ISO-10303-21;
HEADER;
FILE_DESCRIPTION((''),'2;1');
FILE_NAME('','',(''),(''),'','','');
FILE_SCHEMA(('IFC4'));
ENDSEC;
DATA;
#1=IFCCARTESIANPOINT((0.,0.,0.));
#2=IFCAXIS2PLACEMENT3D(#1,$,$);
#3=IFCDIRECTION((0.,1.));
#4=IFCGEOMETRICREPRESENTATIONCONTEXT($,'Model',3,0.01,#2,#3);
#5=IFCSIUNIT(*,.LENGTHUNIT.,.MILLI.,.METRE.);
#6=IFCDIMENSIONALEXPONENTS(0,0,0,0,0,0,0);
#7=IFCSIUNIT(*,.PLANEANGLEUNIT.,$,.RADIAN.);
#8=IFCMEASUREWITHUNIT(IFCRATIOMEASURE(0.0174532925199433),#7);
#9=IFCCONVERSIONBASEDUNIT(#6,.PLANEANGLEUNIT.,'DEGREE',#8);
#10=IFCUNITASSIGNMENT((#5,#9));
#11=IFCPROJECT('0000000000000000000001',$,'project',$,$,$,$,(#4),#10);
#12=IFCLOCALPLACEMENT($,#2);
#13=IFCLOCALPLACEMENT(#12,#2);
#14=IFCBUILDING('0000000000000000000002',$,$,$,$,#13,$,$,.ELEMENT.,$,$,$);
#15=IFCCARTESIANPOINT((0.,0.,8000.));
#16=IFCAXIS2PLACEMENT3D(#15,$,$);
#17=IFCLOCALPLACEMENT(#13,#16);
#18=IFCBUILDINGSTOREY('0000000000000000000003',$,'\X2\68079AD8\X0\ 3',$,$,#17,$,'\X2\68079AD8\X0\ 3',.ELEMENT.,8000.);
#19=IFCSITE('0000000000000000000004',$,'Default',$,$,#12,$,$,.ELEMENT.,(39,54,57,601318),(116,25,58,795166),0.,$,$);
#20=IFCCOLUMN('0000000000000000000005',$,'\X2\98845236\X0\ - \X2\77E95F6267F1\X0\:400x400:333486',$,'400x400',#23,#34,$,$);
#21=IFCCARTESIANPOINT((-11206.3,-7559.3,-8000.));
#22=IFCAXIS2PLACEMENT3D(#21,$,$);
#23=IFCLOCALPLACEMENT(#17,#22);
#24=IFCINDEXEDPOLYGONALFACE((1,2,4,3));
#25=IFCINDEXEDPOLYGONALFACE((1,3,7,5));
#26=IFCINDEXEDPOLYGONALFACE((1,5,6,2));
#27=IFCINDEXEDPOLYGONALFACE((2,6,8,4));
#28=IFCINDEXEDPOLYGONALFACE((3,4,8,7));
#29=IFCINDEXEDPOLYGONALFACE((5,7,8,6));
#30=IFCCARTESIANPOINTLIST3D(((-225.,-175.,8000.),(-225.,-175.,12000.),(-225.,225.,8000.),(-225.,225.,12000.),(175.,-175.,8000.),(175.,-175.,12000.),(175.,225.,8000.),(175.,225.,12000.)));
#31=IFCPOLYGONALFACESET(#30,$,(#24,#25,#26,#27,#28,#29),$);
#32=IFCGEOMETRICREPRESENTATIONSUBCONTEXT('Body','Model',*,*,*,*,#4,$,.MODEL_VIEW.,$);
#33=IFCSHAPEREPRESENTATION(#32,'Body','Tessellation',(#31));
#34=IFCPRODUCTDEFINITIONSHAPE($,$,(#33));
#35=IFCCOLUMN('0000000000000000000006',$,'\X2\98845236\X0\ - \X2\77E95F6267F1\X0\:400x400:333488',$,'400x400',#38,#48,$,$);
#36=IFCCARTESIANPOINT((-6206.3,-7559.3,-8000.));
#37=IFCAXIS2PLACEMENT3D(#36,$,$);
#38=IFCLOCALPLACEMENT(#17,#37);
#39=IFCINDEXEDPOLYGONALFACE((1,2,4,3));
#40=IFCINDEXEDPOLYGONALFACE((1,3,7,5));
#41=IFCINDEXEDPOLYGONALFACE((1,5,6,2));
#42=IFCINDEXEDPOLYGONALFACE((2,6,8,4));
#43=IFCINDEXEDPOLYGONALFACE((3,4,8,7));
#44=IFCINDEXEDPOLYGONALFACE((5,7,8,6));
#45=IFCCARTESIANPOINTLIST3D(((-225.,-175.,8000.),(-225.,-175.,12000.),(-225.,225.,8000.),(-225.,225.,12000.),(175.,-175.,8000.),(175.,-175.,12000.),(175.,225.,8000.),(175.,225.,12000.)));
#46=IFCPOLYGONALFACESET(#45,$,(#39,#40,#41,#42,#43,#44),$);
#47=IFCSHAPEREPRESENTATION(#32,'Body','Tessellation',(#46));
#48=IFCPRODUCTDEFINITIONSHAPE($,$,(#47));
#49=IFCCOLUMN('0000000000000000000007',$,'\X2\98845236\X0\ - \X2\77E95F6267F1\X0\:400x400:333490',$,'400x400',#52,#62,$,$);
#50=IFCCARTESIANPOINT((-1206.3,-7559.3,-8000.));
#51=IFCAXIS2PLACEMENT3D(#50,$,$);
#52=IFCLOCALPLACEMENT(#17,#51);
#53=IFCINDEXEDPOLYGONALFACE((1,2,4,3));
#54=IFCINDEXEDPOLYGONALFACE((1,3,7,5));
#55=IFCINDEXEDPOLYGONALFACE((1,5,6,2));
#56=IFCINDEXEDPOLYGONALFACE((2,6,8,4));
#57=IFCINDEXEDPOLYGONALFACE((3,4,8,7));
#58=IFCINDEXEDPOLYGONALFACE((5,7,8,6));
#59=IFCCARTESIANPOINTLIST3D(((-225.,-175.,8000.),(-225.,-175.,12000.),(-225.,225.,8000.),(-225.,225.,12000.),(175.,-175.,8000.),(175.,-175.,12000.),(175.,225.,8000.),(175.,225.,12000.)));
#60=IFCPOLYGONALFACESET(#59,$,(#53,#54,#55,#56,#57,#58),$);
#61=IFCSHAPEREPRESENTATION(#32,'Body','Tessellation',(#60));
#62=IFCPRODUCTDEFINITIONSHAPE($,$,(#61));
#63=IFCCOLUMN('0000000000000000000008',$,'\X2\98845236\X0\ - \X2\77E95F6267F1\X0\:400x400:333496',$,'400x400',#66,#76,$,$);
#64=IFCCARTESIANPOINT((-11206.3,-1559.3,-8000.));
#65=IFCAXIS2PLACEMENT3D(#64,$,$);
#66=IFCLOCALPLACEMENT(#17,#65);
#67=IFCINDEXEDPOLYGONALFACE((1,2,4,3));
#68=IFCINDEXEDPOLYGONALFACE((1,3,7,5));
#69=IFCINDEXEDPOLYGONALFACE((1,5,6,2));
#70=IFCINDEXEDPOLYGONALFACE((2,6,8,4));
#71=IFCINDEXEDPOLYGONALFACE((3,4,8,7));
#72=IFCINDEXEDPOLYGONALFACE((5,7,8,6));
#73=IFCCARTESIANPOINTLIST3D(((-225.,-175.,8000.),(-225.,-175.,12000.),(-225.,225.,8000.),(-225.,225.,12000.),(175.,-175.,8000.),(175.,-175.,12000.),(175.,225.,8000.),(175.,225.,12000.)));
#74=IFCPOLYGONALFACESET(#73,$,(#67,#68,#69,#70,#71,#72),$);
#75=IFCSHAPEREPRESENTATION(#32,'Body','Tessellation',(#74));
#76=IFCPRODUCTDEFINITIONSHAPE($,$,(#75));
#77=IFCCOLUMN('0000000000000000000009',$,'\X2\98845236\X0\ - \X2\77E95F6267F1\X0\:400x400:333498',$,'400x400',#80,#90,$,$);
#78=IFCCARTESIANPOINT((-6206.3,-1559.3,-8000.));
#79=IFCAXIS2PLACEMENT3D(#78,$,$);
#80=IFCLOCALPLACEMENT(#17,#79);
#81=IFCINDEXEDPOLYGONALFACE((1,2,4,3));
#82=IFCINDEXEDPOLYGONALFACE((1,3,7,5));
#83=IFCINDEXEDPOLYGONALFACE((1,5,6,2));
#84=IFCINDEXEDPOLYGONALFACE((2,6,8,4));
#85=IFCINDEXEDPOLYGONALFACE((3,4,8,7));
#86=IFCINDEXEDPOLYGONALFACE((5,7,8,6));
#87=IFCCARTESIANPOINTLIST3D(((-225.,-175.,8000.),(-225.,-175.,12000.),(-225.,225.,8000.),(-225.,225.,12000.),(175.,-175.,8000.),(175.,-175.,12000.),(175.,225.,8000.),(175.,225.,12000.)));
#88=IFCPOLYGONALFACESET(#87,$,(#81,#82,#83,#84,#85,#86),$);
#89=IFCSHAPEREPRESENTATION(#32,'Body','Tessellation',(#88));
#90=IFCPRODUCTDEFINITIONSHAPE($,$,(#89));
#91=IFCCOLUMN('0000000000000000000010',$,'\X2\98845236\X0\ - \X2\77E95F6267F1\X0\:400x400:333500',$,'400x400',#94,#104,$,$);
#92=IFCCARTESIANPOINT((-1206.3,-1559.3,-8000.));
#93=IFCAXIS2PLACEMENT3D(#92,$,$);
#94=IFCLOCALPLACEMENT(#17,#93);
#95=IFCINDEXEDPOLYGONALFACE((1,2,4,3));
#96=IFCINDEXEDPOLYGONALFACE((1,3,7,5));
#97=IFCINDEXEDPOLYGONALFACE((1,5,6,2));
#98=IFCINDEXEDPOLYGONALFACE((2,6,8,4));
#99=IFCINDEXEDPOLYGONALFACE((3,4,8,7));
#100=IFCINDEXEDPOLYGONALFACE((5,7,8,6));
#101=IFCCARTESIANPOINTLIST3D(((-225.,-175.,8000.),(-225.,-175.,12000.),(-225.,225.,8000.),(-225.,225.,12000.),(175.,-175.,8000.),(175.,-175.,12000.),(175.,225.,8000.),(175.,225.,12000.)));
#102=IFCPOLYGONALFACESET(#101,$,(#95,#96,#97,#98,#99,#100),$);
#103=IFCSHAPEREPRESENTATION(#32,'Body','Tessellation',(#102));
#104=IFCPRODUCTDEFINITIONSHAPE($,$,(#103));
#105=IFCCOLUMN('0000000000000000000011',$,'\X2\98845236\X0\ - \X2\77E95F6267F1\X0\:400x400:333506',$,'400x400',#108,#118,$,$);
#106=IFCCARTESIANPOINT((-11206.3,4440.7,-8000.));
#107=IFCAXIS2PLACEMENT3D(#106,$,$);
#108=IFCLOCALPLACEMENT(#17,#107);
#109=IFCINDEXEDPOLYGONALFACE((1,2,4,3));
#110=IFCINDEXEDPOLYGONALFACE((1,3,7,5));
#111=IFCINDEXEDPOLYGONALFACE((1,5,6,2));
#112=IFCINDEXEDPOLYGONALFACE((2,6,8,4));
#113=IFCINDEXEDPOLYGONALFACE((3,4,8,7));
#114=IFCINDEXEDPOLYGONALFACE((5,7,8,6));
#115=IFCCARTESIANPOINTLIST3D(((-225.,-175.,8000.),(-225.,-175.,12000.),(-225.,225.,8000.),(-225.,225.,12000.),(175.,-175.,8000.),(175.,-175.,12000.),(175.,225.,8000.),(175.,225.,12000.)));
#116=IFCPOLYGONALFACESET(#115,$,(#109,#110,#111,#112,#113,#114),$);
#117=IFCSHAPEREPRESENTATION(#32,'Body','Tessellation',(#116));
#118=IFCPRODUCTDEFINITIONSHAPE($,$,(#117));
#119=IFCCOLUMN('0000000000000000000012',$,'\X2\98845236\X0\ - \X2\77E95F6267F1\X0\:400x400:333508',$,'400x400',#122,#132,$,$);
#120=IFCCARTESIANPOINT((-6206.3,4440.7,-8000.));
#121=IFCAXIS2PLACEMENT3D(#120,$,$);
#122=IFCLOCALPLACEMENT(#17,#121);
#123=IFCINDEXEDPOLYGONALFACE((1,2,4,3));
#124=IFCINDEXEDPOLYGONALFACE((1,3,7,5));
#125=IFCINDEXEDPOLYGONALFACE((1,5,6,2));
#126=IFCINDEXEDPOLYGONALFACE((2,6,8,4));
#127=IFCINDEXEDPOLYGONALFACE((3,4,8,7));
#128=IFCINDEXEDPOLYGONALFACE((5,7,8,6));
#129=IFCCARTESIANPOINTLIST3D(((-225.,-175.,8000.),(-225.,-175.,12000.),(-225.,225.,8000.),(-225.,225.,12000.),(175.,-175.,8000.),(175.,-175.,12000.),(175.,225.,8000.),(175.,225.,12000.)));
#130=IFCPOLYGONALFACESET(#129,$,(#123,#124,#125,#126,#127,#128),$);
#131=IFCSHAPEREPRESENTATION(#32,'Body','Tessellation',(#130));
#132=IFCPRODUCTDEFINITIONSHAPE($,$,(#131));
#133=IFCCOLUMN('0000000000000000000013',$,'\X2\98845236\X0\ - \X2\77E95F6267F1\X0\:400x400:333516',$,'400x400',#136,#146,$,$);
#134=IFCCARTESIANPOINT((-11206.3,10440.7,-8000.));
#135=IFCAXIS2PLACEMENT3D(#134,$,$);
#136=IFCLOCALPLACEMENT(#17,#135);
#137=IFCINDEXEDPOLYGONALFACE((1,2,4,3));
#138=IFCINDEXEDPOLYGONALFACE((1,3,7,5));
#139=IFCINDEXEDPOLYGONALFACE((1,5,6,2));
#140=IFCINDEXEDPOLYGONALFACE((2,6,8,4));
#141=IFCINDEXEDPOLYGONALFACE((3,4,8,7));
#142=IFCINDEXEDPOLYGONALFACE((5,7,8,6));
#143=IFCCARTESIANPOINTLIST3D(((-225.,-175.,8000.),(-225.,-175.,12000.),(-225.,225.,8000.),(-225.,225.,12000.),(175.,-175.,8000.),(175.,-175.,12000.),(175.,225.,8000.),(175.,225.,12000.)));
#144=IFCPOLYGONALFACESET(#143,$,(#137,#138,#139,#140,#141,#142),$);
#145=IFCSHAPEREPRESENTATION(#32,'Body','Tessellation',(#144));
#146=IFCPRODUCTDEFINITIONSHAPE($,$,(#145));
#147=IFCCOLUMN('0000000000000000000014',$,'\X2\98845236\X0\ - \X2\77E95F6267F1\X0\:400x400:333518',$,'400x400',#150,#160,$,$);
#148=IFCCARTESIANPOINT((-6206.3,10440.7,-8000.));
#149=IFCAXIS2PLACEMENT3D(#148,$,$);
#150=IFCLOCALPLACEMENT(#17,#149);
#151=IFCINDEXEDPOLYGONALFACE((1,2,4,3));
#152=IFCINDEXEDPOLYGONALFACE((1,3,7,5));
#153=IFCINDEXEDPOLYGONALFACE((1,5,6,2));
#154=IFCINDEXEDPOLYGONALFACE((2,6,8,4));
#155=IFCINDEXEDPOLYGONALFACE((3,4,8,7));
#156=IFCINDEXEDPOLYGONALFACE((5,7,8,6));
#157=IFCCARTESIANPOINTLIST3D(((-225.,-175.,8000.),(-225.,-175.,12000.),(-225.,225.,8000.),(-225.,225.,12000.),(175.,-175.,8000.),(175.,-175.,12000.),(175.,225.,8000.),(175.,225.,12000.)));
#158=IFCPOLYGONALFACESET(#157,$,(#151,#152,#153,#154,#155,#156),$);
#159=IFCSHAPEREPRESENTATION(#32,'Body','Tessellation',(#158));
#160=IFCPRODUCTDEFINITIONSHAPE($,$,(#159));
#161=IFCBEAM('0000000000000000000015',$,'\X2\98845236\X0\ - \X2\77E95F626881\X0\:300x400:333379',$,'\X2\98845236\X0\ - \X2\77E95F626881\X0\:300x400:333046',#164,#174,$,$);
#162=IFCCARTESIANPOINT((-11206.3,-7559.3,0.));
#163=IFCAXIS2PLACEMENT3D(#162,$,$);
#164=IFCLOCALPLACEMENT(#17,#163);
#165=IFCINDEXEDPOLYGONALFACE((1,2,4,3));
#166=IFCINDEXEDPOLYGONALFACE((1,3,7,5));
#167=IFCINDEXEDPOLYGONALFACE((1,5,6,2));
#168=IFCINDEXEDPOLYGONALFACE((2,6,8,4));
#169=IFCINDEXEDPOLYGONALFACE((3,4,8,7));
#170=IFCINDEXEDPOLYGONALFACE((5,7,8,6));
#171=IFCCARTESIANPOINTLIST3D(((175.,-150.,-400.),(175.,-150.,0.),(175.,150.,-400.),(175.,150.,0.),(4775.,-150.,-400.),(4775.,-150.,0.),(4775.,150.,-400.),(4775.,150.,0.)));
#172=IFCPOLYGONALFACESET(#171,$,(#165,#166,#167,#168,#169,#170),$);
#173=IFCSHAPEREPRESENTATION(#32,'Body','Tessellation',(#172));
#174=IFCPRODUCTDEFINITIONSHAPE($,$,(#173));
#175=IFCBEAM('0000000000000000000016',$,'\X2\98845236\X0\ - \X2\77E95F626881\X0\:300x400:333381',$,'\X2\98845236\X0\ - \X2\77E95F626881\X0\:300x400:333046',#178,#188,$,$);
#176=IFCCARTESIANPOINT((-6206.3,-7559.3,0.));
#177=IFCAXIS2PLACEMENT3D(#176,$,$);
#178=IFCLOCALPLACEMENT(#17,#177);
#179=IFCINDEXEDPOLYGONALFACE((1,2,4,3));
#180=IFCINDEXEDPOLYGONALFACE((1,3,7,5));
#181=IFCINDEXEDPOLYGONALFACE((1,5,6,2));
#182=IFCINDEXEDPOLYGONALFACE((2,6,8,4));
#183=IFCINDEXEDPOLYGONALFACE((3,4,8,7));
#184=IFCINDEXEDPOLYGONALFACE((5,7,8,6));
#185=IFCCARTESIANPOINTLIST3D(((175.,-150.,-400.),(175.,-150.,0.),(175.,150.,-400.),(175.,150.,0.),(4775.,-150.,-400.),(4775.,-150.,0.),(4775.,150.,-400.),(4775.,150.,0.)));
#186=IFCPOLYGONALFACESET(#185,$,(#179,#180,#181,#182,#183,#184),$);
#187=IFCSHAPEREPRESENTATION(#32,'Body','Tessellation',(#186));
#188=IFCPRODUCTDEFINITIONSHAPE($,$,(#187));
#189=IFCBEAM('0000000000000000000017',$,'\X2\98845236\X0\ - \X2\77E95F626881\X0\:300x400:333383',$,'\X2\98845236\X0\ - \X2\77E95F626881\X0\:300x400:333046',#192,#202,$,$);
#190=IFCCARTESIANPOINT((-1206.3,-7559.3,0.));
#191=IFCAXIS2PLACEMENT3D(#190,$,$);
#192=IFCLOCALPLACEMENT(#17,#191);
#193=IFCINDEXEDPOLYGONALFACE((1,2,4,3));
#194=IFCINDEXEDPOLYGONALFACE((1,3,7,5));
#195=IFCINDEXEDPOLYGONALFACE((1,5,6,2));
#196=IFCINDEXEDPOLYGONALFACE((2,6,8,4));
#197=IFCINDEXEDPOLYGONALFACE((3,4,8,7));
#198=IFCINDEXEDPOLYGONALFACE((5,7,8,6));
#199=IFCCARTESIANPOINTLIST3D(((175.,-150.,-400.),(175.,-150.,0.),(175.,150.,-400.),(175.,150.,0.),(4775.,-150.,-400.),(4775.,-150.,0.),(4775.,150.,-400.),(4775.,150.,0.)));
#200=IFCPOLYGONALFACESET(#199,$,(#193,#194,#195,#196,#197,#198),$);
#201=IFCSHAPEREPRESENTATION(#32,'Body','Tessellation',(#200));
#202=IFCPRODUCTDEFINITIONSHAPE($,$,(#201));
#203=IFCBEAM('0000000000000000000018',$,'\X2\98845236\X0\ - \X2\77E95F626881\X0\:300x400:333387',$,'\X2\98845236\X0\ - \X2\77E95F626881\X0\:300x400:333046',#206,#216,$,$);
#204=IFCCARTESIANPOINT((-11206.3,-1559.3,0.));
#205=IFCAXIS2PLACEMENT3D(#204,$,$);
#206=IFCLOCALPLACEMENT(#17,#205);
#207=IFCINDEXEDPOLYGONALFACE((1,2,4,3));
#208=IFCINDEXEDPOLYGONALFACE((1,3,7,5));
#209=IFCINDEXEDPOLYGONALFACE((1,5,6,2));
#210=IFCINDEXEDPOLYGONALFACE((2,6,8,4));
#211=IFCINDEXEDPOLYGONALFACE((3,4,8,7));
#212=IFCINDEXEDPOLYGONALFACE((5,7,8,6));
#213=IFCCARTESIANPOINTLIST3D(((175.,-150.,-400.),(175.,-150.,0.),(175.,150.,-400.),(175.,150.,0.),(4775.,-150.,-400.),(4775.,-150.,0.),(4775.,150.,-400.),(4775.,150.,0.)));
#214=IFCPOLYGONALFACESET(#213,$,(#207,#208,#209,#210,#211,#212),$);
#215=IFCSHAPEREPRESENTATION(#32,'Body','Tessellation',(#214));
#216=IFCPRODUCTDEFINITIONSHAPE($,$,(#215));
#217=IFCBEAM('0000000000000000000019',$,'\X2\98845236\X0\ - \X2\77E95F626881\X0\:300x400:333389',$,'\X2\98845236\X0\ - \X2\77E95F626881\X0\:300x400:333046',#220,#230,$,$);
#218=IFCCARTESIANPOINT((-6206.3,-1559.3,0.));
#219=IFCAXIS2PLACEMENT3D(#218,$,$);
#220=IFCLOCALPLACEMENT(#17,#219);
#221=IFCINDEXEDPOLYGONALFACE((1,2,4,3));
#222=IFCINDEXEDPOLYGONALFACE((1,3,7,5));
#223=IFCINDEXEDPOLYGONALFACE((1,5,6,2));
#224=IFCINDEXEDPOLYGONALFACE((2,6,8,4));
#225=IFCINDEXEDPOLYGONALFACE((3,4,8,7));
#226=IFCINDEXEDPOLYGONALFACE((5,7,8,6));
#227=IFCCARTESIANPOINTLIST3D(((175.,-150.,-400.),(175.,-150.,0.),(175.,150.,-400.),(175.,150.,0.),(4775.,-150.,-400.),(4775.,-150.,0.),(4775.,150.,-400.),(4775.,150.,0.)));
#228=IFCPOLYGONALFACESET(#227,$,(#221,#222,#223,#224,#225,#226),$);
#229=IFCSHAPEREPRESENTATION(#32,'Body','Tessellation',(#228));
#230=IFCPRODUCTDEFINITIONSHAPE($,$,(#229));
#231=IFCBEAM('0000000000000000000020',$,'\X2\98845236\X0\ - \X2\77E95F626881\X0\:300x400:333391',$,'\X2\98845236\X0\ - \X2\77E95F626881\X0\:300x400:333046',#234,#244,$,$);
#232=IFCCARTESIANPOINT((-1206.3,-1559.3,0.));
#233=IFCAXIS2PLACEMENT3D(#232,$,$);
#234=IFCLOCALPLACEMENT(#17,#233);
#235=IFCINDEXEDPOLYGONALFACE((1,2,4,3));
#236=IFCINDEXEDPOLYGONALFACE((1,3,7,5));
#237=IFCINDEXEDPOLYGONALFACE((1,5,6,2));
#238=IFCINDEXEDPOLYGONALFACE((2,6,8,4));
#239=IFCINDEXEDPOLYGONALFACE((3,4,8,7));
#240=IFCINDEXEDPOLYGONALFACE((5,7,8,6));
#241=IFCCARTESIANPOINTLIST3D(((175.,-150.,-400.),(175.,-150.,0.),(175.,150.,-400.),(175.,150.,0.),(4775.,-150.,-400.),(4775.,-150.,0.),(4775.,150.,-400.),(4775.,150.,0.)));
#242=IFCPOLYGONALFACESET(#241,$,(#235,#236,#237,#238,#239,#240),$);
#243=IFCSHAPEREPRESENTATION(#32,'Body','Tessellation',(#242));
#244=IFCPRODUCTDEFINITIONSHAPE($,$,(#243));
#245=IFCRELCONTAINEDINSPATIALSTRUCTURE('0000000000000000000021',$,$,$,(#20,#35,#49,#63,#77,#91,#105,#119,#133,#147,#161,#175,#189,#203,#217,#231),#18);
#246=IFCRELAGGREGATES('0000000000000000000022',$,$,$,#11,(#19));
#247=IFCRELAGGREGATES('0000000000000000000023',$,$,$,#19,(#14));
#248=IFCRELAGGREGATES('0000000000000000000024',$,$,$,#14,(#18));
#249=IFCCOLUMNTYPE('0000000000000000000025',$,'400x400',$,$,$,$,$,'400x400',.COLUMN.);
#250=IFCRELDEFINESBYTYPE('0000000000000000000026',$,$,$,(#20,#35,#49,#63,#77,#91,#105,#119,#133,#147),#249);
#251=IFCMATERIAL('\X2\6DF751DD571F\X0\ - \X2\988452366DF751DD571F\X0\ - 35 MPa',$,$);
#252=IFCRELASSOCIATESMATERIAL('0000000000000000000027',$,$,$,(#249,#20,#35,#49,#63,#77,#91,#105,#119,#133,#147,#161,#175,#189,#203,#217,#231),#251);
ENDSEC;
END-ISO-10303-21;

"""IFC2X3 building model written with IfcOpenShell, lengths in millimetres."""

from ifc_helpers import new_model, entity, si_unit, converted_unit, direction, frame, frame_2d, origin, place, context, subcontext, project, spatial, rectangle, extrude, source, transform, mapped, material, type_object, type_shapes, element, save


model = new_model("IFC2X3")

# Units and contexts
model_context = context("Model", 3, precision=0.01, world=origin(), true_north=direction((0.0, 1.0)))
body_context = subcontext(model_context, "Body", "Model", "MODEL_VIEW")
ifc_project = project(units=[si_unit("LENGTHUNIT", "METRE", prefix="MILLI"), converted_unit("PLANEANGLEUNIT", "DEGREE", entity("IfcRatioMeasure", 0.0174532925199433), si_unit("PLANEANGLEUNIT", "RADIAN"), dimensions=[0, 0, 0, 0, 0, 0, 0])], contexts=[model_context])

# Site, building, storey
site_placement = place(None, origin())
site = spatial("IfcSite", under=ifc_project, at=site_placement, Name="Default", CompositionType="ELEMENT", RefLatitude=(39, 54, 57, 601318), RefLongitude=(116, 25, 58, 795166), RefElevation=0.0)
building_placement = place(site_placement, origin())
building = spatial("IfcBuilding", under=site, at=building_placement, CompositionType="ELEMENT")
storey_placement = place(building_placement, frame((0.0, 0.0, 8000.0)))
storey = spatial("IfcBuildingStorey", under=building, at=storey_placement, Name="标高 3", LongName="标高 3", CompositionType="ELEMENT", Elevation=8000.0)

# Columns
ifc_material = material(Name="混凝土 - 预制混凝土 - 35 MPa")
column_type = type_object("IfcColumnType", Name="400x400", ElementType="400x400", PredefinedType="COLUMN", material=ifc_material)
shared_shape = source(origin(), body_context, "Body", "SweptSolid", [
    extrude(rectangle(XDim=400.0, YDim=400.0, at=frame_2d((0.0, 0.0), x_axis=(1.0, 0.0))), frame((-25.0, 25.0, 8000.0)), (0.0, 0.0, 1.0), 4000.0),
])
type_shapes(column_type, [shared_shape])
for number, where, name in (
    (1, (-11206.3, -7559.3, -8000.0), "预制 - 矩形柱:400x400:333486"),
    (2, (-6206.3, -7559.3, -8000.0), "预制 - 矩形柱:400x400:333488"),
    (3, (-1206.3, -7559.3, -8000.0), "预制 - 矩形柱:400x400:333490"),
    (4, (-11206.3, -1559.3, -8000.0), "预制 - 矩形柱:400x400:333496"),
    (5, (-6206.3, -1559.3, -8000.0), "预制 - 矩形柱:400x400:333498"),
    (6, (-1206.3, -1559.3, -8000.0), "预制 - 矩形柱:400x400:333500"),
    (7, (-11206.3, 4440.7, -8000.0), "预制 - 矩形柱:400x400:333506"),
    (8, (-6206.3, 4440.7, -8000.0), "预制 - 矩形柱:400x400:333508"),
    (9, (-11206.3, 10440.7, -8000.0), "预制 - 矩形柱:400x400:333516"),
    (10, (-6206.3, 10440.7, -8000.0), "预制 - 矩形柱:400x400:333518"),
):
    element("IfcColumn", number, at=place(storey_placement, frame(where)), inside=storey, type_object=column_type, material=ifc_material, Name=name, ObjectType="400x400", context=body_context, shape_type="MappedRepresentation", body=[
        mapped(shared_shape, transform((0.0, 0.0, 0.0), scale=1.0)),
    ])

# Beams
for number, where, name in (
    (11, (-11206.3, -7559.3, 0.0), "预制 - 矩形梁:300x400:333379"),
    (12, (-6206.3, -7559.3, 0.0), "预制 - 矩形梁:300x400:333381"),
):
    element("IfcBeam", number, at=place(storey_placement, frame(where)), inside=storey, material=ifc_material, Name=name, ObjectType="预制 - 矩形梁:300x400:333046", context=body_context, shape_type="SweptSolid", body=[
        extrude(rectangle(XDim=400.0, YDim=300.0, at=frame_2d((0.0, 0.0), x_axis=(1.0, 0.0))), frame((175.0, 0.0, -200.0), z_axis=(1.0, 0.0, 0.0), x_axis=(0.0, 0.0, -1.0)), (0.0, 0.0, 1.0), 4600.0),
    ])
beam_1_placement = place(storey_placement, frame((-1206.3, -7559.3, 0.0)))
element("IfcBeam", 13, at=beam_1_placement, inside=storey, material=ifc_material, Name="预制 - 矩形梁:300x400:333383", ObjectType="预制 - 矩形梁:300x400:333046", context=body_context, shape_type="SweptSolid", body=[
    extrude(rectangle(XDim=400.0, YDim=300.0, at=frame_2d((0.0, 0.0), x_axis=(1.0, 0.0))), frame((175.0, 0.0, -200.0), z_axis=(1.0, 0.0, 0.0), x_axis=(0.0, 0.0, -1.0)), (0.0, 0.0, 1.0), 4600.0),
])
for number, where, name in (
    (14, (-11206.3, -1559.3, 0.0), "预制 - 矩形梁:300x400:333387"),
    (15, (-6206.3, -1559.3, 0.0), "预制 - 矩形梁:300x400:333389"),
    (16, (-1206.3, -1559.3, 0.0), "预制 - 矩形梁:300x400:333391"),
):
    element("IfcBeam", number, at=place(storey_placement, frame(where)), inside=storey, material=ifc_material, Name=name, ObjectType="预制 - 矩形梁:300x400:333046", context=body_context, shape_type="SweptSolid", body=[
        extrude(rectangle(XDim=400.0, YDim=300.0, at=frame_2d((0.0, 0.0), x_axis=(1.0, 0.0))), frame((175.0, 0.0, -200.0), z_axis=(1.0, 0.0, 0.0), x_axis=(0.0, 0.0, -1.0)), (0.0, 0.0, 1.0), 4600.0),
    ])

save(model, "model.ifc")
